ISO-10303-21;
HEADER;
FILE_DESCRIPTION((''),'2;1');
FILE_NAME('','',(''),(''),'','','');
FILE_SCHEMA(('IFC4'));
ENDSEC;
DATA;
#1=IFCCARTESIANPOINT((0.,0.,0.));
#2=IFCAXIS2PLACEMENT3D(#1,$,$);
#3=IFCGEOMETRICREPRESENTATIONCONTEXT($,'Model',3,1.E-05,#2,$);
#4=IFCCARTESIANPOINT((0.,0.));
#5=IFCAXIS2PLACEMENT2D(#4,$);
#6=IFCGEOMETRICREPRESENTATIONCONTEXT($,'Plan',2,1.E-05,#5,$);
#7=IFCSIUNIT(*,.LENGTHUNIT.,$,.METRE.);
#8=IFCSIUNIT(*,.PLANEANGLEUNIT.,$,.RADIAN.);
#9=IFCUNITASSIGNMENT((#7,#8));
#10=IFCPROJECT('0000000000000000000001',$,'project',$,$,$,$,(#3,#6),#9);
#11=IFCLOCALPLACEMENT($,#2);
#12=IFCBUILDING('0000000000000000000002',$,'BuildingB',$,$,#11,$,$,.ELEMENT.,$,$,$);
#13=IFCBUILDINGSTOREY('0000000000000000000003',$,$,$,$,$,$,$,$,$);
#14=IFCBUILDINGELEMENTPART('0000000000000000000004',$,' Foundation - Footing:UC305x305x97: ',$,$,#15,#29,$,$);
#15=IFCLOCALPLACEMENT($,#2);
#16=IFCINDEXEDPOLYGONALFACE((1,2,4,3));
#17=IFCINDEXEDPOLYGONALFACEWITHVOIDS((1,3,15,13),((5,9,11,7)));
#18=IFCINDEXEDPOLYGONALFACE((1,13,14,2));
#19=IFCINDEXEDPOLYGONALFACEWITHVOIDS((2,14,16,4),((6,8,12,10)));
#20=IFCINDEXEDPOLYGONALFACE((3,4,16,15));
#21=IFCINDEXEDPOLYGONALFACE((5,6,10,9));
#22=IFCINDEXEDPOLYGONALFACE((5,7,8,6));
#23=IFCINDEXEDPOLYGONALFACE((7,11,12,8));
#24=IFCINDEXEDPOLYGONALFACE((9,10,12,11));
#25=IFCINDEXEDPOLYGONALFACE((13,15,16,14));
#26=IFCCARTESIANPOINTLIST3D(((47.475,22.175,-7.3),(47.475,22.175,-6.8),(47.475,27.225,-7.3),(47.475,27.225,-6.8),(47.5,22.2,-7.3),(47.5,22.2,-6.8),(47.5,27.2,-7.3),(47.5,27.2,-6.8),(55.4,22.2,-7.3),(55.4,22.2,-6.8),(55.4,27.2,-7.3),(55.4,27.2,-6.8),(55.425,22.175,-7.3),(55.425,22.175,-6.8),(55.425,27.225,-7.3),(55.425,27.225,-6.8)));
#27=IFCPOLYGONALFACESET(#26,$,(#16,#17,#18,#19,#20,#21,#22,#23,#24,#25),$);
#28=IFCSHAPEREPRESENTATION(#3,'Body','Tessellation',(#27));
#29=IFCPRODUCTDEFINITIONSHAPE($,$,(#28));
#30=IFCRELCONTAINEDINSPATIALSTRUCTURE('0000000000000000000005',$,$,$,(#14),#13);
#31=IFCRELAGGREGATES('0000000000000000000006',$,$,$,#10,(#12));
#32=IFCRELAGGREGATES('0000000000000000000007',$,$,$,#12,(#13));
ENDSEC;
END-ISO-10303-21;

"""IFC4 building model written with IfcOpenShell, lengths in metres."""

from ifc_helpers import new_model, si_unit, origin, origin_2d, place, context, project, spatial, polyline, outline, extrude, element, save


model = new_model("IFC4")

# Units and contexts
model_context = context("Model", 3, precision=1e-05, world=origin())
plan_context = context("Plan", 2, precision=1e-05, world=origin_2d())
ifc_project = project(units=[si_unit("LENGTHUNIT", "METRE"), si_unit("PLANEANGLEUNIT", "RADIAN")], contexts=[model_context, plan_context])

# Building, storey
building_placement = place(None, origin())
building = spatial("IfcBuilding", under=ifc_project, at=building_placement, Name="BuildingB", CompositionType="ELEMENT")
storey = spatial("IfcBuildingStorey", under=building)

# Building element part, opening
building_element_part_1 = element("IfcBuildingElementPart", 1, inside=storey, Name=" Foundation - Footing:UC305x305x97: ", context=model_context, shape_type="SweptSolid", body=[
    extrude(outline(polyline([(55.425, 27.225, -7.3), (47.475, 27.225, -7.3), (47.475, 22.175, -7.3), (55.425, 22.175, -7.3), (55.425, 27.225, -7.3)])), None, (0.0, 0.0, 1.0), 0.5),
])
element("IfcOpeningElement", 2, inside=storey, cuts=building_element_part_1, context=model_context, shape_type="SweptSolid", body=[
    extrude(outline(polyline([(55.4, 27.2, -7.3), (47.5, 27.2, -7.3), (47.5, 22.2, -7.3), (55.4, 22.2, -7.3), (55.4, 27.2, -7.3)])), None, (0.0, 0.0, 1.0), 0.5),
])

save(model, "model.ifc")
